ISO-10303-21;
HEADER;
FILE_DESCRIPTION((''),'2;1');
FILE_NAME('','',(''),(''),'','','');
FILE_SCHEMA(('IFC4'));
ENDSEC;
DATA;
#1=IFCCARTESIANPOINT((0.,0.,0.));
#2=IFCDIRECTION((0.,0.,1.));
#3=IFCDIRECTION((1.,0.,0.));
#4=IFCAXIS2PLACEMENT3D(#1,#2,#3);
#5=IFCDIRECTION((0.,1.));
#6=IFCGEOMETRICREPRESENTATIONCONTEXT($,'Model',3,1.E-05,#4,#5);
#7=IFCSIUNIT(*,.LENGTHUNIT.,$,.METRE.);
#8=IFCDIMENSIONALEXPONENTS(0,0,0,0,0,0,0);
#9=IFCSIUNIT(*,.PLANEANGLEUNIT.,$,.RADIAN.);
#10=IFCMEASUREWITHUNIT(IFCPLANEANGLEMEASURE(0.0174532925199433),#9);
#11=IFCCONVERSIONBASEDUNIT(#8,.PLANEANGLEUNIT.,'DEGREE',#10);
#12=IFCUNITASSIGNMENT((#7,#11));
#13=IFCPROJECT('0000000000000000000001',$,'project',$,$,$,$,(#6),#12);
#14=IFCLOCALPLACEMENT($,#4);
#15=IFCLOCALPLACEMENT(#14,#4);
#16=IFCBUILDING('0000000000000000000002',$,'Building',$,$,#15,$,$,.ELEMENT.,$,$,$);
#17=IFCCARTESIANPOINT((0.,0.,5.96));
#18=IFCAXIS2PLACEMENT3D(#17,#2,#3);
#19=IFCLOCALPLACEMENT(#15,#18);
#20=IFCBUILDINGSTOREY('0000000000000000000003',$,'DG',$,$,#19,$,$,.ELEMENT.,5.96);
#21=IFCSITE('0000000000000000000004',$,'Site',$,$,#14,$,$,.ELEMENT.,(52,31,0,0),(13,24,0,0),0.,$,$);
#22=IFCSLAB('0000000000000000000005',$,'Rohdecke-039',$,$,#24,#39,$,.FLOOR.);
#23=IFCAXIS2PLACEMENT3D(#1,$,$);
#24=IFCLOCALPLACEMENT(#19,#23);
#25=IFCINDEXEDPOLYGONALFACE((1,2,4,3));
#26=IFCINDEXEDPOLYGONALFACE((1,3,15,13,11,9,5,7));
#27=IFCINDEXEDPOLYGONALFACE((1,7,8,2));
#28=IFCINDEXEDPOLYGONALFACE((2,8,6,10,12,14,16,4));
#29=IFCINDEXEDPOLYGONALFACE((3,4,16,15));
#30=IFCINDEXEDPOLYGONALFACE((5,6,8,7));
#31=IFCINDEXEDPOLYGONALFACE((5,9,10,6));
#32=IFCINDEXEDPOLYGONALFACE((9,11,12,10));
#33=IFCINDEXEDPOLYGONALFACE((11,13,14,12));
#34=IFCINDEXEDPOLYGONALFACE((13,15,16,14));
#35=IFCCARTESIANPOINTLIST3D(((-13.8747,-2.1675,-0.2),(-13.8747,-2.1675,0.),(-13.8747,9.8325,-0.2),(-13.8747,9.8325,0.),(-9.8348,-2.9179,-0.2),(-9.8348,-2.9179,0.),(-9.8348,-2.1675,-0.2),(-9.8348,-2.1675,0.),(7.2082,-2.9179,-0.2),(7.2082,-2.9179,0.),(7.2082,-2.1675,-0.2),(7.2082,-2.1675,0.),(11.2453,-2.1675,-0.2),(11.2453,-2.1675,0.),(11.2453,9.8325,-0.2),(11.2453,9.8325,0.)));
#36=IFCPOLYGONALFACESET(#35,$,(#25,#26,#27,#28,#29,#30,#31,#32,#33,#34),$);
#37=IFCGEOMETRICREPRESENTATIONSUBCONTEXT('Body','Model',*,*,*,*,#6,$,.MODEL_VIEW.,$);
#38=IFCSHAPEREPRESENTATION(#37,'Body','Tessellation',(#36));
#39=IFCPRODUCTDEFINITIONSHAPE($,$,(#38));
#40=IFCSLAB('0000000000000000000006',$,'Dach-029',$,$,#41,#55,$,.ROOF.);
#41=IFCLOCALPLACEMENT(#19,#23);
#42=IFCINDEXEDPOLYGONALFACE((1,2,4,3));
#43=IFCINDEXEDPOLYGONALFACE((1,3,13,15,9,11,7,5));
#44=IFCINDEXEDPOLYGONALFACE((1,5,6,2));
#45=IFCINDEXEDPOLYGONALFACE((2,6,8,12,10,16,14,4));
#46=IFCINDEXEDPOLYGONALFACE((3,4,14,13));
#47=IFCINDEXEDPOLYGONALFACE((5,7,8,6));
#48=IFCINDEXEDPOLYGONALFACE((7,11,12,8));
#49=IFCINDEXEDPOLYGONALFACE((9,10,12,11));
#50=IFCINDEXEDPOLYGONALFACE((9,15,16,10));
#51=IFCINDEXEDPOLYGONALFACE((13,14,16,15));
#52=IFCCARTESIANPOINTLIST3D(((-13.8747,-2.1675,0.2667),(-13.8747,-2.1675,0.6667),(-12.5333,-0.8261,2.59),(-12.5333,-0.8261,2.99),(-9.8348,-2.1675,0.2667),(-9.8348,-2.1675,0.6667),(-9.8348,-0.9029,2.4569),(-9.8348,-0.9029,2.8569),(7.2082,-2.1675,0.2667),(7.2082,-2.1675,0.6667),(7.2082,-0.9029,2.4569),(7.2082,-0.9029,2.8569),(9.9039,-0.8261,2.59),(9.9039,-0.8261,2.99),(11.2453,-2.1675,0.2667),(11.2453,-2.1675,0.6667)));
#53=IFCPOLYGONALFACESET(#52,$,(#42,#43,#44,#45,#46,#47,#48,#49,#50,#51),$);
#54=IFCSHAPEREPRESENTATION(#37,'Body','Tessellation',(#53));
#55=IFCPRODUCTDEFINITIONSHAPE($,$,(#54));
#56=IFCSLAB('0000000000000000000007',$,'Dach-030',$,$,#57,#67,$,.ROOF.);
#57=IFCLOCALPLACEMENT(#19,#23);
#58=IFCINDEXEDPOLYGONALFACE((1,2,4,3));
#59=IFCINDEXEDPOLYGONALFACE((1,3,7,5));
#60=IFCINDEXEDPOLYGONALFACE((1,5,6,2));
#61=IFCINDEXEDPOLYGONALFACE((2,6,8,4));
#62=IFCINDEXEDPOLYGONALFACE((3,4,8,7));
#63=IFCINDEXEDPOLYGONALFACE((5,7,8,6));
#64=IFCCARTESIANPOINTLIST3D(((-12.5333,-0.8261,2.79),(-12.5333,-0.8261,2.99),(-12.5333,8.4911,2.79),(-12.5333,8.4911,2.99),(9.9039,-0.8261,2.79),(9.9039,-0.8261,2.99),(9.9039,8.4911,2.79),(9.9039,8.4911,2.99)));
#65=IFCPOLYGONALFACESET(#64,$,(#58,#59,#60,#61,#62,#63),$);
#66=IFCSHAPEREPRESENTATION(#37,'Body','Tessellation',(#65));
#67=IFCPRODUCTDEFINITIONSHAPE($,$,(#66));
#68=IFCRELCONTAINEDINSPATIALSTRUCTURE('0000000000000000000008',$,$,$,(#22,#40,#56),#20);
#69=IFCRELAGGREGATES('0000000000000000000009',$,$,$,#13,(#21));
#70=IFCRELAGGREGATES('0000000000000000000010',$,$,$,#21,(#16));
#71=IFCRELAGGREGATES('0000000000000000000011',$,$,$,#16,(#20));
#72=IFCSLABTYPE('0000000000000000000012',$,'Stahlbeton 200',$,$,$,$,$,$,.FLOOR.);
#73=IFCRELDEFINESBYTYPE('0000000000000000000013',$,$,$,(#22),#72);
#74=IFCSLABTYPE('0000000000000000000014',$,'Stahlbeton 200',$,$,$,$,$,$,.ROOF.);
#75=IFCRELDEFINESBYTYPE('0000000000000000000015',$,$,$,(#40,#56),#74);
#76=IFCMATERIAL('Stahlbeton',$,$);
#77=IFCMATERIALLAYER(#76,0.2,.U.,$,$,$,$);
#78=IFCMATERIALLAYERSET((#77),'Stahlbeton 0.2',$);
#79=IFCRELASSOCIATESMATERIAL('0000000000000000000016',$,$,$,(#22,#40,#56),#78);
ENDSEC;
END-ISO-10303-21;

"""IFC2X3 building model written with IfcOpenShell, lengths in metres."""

from ifc_helpers import new_model, entity, si_unit, converted_unit, direction, frame, origin_with_axes, place, context, subcontext, project, spatial, polyline, outline, extrude, material, layer, layer_set, layer_usage, type_object, element, save


model = new_model("IFC2X3")

# Units and contexts
model_context = context("Model", 3, precision=1e-05, world=origin_with_axes(), true_north=direction((0.0, 1.0)))
body_context = subcontext(model_context, "Body", "Model", "MODEL_VIEW")
ifc_project = project(units=[si_unit("LENGTHUNIT", "METRE"), converted_unit("PLANEANGLEUNIT", "DEGREE", entity("IfcPlaneAngleMeasure", 0.0174532925199433), si_unit("PLANEANGLEUNIT", "RADIAN"), dimensions=[0, 0, 0, 0, 0, 0, 0])], contexts=[model_context])

# Site, building, storey
site_placement = place(None, origin_with_axes())
site = spatial("IfcSite", under=ifc_project, at=site_placement, Name="Site", CompositionType="ELEMENT", RefLatitude=(52, 31, 0, 0), RefLongitude=(13, 24, 0, 0), RefElevation=0.0)
building_placement = place(site_placement, origin_with_axes())
building = spatial("IfcBuilding", under=site, at=building_placement, Name="Building", CompositionType="ELEMENT")
storey_placement = place(building_placement, frame((0.0, 0.0, 5.96), z_axis=(0.0, 0.0, 1.0), x_axis=(1.0, 0.0, 0.0)))
storey = spatial("IfcBuildingStorey", under=building, at=storey_placement, Name="DG", CompositionType="ELEMENT", Elevation=5.96)

# Slabs
ifc_material = material(Name="Stahlbeton")
ifc_layer = layer(ifc_material, 0.2, ventilated="UNKNOWN")
ifc_layer_set = layer_set([ifc_layer], Name="Stahlbeton 0.2")
ifc_layer_usage_1 = layer_usage(ifc_layer_set, "AXIS3", "NEGATIVE", 0.2)
slab_type_1 = type_object("IfcSlabType", Name="Stahlbeton 200", PredefinedType="FLOOR")
slab_1_placement = place(storey_placement, frame((11.2453, 9.8325, 0.0), z_axis=(0.0, 0.0, 1.0), x_axis=(1.0, 0.0, 0.0)))
element("IfcSlab", 1, at=slab_1_placement, inside=storey, type_object=slab_type_1, material=ifc_layer_usage_1, Name="Rohdecke-039", PredefinedType="FLOOR", context=body_context, shape_type="SweptSolid", body=[
    extrude(outline(polyline([(0.0, 0.0), (-25.12, 0.0), (-25.12, -12.0), (-21.08, -12.0), (-21.08, -12.7505), (-4.037, -12.7505), (-4.037, -12.0), (0.0, -12.0), (0.0, 0.0)])), frame((0.0, 0.0, -0.2), z_axis=(0.0, 0.0, 1.0), x_axis=(1.0, 0.0, 0.0)), (0.0, 0.0, 1.0), 0.2),
])
ifc_layer_usage_2 = layer_usage(ifc_layer_set, "AXIS3", "NEGATIVE", 0.2)
slab_type_2 = type_object("IfcSlabType", Name="Stahlbeton 200", PredefinedType="ROOF")
slab_2_placement = place(storey_placement, frame((-13.8747, -2.1675, 0.2667), z_axis=(0.0, 0.0, 1.0), x_axis=(1.0, 0.0, 0.0)))
element("IfcSlab", 2, at=slab_2_placement, inside=storey, type_object=slab_type_2, material=ifc_layer_usage_2, Name="Dach-029", PredefinedType="ROOF", context=body_context, shape_type="SweptSolid", body=[
    extrude(outline(polyline([(1.3414, 2.6827), (0.0, 0.0), (4.04, 0.0), (4.04, 2.5291), (21.083, 2.5291), (21.083, 0.0), (25.12, 0.0), (23.7786, 2.6827), (1.3414, 2.6827)])), frame((0.0, 0.0, 0.0), z_axis=(0.0, -0.866025, 0.5), x_axis=(1.0, 0.0, 0.0)), (0.0, 0.866025, 0.5), 0.4),
])
ifc_layer_usage_3 = layer_usage(ifc_layer_set, "AXIS3", "NEGATIVE", 0.2)
slab_3_placement = place(storey_placement, frame((-12.5333, 8.4911, 2.79), z_axis=(0.0, 0.0, 1.0), x_axis=(0.0, -1.0, 0.0)))
element("IfcSlab", 3, at=slab_3_placement, inside=storey, type_object=slab_type_2, material=ifc_layer_usage_3, Name="Dach-030", PredefinedType="ROOF", context=body_context, shape_type="SweptSolid", body=[
    extrude(outline(polyline([(9.3173, 0.0), (9.3173, 22.4373), (0.0, 22.4373), (0.0, 0.0), (9.3173, 0.0)])), origin_with_axes(), (0.0, 0.0, 1.0), 0.2),
])

save(model, "model.ifc")
